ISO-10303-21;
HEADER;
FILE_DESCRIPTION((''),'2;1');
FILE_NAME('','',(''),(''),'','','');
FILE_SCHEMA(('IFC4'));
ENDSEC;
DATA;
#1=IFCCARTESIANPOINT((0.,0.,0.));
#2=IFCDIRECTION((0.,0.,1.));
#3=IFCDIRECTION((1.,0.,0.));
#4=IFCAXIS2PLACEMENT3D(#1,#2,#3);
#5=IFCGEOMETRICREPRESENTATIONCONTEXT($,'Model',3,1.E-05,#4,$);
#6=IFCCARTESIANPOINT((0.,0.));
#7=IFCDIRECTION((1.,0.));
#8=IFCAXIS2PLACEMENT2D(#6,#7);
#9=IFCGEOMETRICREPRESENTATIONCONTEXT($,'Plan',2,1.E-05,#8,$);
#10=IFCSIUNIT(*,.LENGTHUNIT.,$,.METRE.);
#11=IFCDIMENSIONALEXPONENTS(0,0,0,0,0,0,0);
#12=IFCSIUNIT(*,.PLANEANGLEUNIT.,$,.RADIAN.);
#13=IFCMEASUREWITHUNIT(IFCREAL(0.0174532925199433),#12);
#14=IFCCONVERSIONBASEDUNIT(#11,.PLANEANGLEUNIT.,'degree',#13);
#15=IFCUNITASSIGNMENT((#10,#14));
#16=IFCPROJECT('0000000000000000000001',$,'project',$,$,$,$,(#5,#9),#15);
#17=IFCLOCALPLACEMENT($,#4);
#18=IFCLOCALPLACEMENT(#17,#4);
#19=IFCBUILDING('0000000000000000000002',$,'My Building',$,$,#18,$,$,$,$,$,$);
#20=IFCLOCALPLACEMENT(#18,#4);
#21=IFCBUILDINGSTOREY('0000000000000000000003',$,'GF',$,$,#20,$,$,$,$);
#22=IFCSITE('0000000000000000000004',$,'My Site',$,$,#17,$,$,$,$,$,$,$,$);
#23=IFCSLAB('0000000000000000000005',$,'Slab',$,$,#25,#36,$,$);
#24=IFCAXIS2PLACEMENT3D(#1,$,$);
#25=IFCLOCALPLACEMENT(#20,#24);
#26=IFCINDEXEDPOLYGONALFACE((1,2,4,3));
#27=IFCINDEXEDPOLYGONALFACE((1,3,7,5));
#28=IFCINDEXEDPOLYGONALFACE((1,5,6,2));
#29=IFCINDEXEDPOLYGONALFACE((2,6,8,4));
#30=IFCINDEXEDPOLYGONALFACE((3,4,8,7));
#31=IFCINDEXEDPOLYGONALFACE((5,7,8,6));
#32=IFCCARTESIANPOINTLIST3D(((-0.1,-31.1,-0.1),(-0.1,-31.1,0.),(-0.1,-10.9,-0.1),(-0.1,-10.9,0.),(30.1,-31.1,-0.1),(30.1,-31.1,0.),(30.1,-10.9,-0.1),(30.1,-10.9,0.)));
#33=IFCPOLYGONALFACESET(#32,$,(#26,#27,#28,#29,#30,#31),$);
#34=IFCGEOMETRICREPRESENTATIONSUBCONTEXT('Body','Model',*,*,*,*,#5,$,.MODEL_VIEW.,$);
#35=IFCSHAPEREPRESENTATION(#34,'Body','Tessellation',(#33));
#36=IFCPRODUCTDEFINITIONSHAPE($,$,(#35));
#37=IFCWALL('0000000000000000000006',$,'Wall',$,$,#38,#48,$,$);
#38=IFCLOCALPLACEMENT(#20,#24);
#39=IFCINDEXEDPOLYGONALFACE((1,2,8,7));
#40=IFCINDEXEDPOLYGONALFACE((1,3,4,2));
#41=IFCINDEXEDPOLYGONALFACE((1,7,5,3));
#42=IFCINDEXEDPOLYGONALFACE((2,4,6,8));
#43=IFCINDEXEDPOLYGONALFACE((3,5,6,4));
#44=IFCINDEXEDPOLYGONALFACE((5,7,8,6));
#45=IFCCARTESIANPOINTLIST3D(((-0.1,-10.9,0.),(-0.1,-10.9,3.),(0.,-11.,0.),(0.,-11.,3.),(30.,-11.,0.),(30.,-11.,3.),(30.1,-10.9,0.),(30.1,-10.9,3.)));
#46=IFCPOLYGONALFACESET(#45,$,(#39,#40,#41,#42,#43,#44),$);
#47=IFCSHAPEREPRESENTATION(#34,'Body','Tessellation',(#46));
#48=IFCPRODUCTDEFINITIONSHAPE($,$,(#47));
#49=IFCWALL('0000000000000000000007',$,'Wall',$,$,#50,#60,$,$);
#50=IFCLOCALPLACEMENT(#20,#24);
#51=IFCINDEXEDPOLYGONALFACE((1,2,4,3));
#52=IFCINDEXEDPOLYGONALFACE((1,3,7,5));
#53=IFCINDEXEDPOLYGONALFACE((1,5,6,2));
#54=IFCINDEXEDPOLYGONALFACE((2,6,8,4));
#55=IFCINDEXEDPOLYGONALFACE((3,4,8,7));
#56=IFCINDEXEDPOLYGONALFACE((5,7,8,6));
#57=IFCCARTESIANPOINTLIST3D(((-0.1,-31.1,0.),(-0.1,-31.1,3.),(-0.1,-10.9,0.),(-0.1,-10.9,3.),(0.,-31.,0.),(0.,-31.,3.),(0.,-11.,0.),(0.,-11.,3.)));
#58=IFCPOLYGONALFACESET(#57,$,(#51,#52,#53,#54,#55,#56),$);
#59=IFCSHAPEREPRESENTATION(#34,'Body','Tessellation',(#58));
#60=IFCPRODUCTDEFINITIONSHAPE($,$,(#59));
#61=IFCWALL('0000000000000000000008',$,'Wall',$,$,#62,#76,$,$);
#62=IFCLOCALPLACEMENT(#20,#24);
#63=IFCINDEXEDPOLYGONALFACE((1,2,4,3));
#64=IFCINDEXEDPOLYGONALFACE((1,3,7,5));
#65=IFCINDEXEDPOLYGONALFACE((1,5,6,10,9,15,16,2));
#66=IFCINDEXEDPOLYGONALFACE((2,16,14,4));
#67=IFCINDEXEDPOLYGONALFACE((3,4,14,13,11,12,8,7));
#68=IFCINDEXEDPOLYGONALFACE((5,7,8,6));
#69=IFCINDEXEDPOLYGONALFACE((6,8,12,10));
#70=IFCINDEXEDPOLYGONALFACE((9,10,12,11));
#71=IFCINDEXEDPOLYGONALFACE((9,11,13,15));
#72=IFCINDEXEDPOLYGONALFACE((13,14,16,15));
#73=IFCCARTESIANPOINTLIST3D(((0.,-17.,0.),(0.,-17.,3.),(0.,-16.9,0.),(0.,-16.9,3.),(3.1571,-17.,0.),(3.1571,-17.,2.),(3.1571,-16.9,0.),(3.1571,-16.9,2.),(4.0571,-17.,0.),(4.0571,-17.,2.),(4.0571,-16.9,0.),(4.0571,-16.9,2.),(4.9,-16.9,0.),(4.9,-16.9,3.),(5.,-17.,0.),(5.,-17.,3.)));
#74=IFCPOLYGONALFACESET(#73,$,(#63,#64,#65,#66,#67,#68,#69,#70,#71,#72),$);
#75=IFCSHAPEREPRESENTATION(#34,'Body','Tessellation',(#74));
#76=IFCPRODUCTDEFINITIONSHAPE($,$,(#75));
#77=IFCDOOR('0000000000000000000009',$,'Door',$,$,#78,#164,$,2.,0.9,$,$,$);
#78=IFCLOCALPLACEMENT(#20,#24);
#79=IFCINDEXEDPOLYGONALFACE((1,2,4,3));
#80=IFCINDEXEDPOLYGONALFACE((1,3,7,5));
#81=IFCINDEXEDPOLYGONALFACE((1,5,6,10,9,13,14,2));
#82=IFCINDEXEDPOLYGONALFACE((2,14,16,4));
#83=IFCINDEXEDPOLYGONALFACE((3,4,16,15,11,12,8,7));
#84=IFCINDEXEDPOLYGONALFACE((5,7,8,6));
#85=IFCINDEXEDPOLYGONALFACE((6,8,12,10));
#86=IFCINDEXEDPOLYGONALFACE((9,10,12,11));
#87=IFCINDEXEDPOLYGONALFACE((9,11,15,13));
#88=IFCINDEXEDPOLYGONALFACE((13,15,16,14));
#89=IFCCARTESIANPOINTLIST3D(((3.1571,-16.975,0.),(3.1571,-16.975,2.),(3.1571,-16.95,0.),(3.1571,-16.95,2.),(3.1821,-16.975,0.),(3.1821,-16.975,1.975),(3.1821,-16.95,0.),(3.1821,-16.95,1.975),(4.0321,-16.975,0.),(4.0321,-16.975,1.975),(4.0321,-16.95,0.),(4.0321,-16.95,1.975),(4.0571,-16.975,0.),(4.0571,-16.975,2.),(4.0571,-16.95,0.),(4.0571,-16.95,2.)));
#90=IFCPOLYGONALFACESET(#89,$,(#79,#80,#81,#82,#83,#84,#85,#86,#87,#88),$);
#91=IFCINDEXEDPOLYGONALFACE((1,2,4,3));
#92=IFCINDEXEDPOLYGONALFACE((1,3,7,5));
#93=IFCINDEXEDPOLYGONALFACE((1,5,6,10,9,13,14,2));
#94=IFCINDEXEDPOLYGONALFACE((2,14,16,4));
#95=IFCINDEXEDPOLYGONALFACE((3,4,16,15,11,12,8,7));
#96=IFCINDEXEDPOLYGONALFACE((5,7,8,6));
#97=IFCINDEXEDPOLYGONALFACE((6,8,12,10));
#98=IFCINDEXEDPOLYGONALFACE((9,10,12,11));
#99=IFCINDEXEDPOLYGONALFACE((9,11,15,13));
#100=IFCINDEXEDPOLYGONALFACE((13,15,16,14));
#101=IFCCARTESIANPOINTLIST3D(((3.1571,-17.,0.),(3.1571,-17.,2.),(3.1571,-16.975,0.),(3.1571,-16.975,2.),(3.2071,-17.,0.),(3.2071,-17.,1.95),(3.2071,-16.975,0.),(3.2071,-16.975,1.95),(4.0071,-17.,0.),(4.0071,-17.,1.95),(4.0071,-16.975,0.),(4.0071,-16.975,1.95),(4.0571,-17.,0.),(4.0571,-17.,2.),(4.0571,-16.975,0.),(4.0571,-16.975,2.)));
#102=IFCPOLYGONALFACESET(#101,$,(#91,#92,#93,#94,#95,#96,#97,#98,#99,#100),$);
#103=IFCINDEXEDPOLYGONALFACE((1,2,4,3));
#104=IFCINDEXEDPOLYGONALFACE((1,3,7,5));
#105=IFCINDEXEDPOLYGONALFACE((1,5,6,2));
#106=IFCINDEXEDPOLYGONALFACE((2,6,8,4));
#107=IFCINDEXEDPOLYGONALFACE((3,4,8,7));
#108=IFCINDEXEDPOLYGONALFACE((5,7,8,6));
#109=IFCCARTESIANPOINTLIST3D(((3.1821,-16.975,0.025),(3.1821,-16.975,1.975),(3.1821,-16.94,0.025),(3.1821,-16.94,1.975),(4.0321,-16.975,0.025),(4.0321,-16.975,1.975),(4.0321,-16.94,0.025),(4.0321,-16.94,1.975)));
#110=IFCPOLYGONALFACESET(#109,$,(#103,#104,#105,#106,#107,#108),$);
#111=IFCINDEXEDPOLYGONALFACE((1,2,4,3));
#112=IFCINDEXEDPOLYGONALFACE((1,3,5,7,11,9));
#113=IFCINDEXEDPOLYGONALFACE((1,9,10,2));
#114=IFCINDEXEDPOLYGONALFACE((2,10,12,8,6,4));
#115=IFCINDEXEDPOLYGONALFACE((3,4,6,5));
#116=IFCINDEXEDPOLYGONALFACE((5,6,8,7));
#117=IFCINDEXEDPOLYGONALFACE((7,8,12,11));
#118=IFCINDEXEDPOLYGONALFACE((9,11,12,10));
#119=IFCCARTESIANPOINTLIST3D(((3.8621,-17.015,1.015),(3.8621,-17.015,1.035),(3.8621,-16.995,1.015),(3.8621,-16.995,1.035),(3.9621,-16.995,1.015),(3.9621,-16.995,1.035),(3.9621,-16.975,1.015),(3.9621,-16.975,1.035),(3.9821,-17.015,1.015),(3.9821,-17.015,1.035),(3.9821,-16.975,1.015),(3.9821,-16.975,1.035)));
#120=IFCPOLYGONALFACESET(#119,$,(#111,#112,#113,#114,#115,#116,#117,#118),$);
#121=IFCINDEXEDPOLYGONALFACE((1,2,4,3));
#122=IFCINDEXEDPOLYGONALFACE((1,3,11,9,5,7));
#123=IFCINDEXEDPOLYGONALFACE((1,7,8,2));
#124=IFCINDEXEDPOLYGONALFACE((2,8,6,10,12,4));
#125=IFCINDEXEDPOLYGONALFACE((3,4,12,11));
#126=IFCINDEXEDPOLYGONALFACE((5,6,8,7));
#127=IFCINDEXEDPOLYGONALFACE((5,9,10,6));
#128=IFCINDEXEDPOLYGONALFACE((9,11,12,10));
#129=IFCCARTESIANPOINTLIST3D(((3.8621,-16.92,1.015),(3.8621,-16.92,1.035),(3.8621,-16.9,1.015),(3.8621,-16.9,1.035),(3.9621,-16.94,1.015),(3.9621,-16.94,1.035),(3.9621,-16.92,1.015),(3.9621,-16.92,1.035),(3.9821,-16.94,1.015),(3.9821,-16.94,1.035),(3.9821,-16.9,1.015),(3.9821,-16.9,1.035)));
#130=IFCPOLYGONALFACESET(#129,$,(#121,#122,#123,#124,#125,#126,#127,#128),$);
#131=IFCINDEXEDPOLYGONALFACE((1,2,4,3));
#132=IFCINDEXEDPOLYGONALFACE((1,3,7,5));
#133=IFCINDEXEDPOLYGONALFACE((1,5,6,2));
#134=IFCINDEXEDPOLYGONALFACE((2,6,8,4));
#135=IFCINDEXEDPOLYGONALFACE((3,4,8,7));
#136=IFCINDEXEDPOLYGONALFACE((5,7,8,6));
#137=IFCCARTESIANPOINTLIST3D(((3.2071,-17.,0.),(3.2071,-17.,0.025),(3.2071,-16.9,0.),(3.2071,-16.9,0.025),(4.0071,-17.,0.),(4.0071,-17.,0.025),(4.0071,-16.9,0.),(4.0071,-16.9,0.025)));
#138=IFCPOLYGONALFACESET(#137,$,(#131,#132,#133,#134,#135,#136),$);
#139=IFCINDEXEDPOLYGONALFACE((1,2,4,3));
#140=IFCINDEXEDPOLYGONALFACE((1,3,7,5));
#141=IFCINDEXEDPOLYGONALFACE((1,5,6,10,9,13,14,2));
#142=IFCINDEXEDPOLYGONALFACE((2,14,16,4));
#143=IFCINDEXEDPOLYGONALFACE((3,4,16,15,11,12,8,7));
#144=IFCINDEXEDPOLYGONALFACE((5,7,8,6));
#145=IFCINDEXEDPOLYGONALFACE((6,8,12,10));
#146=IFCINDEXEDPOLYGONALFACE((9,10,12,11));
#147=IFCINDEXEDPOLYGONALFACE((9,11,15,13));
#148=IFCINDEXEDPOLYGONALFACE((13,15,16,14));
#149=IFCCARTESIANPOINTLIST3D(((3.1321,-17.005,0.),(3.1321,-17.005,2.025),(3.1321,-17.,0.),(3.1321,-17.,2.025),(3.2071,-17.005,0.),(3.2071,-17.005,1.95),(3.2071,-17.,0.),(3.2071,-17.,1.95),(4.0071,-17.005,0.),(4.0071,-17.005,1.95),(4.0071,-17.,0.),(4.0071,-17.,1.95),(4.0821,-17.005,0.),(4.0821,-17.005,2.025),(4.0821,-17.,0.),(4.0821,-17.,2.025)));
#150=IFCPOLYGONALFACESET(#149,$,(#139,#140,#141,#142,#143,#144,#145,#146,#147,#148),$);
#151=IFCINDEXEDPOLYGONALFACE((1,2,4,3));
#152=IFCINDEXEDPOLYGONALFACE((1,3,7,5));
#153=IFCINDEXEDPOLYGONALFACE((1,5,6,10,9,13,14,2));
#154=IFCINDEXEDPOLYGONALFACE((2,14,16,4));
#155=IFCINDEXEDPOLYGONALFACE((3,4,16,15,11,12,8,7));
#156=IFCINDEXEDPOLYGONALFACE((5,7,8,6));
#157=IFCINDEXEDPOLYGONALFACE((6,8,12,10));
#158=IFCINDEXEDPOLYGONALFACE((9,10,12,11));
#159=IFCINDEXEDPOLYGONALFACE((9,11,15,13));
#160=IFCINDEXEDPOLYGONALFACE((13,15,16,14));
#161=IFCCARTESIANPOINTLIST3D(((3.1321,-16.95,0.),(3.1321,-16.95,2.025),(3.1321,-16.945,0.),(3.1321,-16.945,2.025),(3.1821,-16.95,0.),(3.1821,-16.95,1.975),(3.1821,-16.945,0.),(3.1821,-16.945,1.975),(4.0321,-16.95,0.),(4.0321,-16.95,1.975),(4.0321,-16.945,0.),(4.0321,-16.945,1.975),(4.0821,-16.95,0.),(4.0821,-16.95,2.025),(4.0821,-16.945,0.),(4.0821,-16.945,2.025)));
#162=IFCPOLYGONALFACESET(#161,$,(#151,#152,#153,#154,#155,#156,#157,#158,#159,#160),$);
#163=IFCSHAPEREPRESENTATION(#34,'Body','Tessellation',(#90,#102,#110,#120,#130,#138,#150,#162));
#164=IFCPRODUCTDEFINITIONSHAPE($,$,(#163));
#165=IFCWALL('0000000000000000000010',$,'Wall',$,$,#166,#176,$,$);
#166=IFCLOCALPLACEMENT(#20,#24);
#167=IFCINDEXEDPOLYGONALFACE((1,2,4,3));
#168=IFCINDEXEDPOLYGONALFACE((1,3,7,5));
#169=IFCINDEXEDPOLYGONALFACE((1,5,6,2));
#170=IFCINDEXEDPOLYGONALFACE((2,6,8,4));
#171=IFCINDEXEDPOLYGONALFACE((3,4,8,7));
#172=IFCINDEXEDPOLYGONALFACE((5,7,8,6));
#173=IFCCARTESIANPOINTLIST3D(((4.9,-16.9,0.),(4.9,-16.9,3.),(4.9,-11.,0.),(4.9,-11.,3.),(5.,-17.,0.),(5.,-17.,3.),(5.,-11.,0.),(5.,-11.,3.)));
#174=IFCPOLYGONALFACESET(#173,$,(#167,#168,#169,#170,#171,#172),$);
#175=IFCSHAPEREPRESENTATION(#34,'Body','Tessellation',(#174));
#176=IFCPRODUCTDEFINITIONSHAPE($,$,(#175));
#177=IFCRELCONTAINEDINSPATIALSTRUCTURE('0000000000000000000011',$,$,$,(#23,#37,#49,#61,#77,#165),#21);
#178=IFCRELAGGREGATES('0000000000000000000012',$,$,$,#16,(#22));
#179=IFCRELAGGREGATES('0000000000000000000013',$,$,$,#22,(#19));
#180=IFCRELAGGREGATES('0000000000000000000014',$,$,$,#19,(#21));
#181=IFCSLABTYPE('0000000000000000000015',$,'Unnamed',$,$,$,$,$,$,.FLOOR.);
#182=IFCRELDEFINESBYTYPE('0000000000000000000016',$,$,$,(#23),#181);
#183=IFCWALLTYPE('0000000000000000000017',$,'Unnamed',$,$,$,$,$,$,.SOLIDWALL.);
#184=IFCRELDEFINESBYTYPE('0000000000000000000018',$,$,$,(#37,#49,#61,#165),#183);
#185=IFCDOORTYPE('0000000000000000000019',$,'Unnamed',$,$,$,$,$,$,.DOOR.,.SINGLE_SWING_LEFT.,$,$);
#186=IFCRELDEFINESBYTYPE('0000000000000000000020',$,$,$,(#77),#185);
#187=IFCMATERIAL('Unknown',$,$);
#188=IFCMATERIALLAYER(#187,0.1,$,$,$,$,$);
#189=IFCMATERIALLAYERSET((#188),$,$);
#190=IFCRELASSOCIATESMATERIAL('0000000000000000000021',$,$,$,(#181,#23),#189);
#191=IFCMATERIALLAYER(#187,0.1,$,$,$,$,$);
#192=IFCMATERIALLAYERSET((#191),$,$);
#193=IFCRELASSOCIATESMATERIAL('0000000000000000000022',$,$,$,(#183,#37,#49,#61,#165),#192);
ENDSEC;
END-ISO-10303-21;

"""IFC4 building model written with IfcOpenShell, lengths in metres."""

from ifc_helpers import new_model, entity, si_unit, converted_unit, frame, origin_with_axes, origin_2d_with_axis, place, context, subcontext, project, spatial, line, indexed_curve, outline, extrude, shape, source, transform, mapped, material, layer, layer_set, layer_usage, type_object, type_shapes, element, fill, save


model = new_model("IFC4")

# Units and contexts
model_context = context("Model", 3, precision=1e-05, world=origin_with_axes())
plan_context = context("Plan", 2, precision=1e-05, world=origin_2d_with_axis())
body_context_1 = subcontext(model_context, "Body", "Model", "MODEL_VIEW")
body_context_2 = subcontext(plan_context, "Body", "Plan", "PLAN_VIEW")
ifc_project = project(units=[si_unit("LENGTHUNIT", "METRE"), converted_unit("PLANEANGLEUNIT", "degree", entity("IfcReal", 0.0174532925199433), si_unit("PLANEANGLEUNIT", "RADIAN"), dimensions=[0, 0, 0, 0, 0, 0, 0])], contexts=[model_context, plan_context])

# Site, building, storey
site_placement = place(None, origin_with_axes())
site = spatial("IfcSite", under=ifc_project, at=site_placement, Name="My Site")
building_placement = place(site_placement, origin_with_axes())
building = spatial("IfcBuilding", under=site, at=building_placement, Name="My Building")
storey_placement = place(building_placement, origin_with_axes())
storey = spatial("IfcBuildingStorey", under=building, at=storey_placement, Name="GF")

# Slab
ifc_material = material(Name="Unknown")
ifc_layer_1 = layer(ifc_material, 0.1)
ifc_layer_set_1 = layer_set([ifc_layer_1])
ifc_layer_usage_1 = layer_usage(ifc_layer_set_1, "AXIS3", "POSITIVE", -0.1)
slab_type = type_object("IfcSlabType", Name="Unnamed", PredefinedType="FLOOR", material=ifc_layer_set_1)
slab_1_placement = place(storey_placement, frame((-0.1, -10.9, 0.0), z_axis=(0.0, 0.0, 1.0), x_axis=(1.0, 0.0, 0.0)))
element("IfcSlab", 1, at=slab_1_placement, inside=storey, type_object=slab_type, material=ifc_layer_usage_1, Name="Slab", context=body_context_1, shape_type="SweptSolid", body=[
    extrude(outline(indexed_curve([(0.0, 0.0), (30.2, 0.0), (30.2, -20.2), (0.0, -20.2), (0.0, 0.0)])), frame((0.0, 0.0, -0.1), z_axis=(0.0, 0.0, 1.0), x_axis=(1.0, 0.0, 0.0)), (0.0, 0.0, 1.0), 0.1),
])

# Walls
ifc_layer_2 = layer(ifc_material, 0.1)
ifc_layer_set_2 = layer_set([ifc_layer_2])
ifc_layer_usage_2 = layer_usage(ifc_layer_set_2, "AXIS2", "POSITIVE", 0.0)
wall_type = type_object("IfcWallType", Name="Unnamed", PredefinedType="SOLIDWALL", material=ifc_layer_set_2)
wall_1_placement = place(storey_placement, frame((0.0, -11.0, 0.0), z_axis=(0.0, 0.0, 1.0), x_axis=(1.0, 0.0, 0.0)))
element("IfcWall", 2, at=wall_1_placement, inside=storey, type_object=wall_type, material=ifc_layer_usage_2, Name="Wall", context=body_context_1, shape_type="SweptSolid", body=[
    extrude(outline(indexed_curve([(0.0, 0.0), (-0.1, 0.1), (30.1, 0.1), (30.0, 0.0)], segments=[line(1, 2, 3, 4, 1)])), origin_with_axes(), (0.0, 0.0, 1.0), 3.0),
])
ifc_layer_usage_3 = layer_usage(ifc_layer_set_2, "AXIS2", "POSITIVE", 0.0)
wall_2_placement = place(storey_placement, frame((0.0, -31.0, 0.0), z_axis=(0.0, 0.0, 1.0), x_axis=(0.0, 1.0, 0.0)))
element("IfcWall", 3, at=wall_2_placement, inside=storey, type_object=wall_type, material=ifc_layer_usage_3, Name="Wall", context=body_context_1, shape_type="SweptSolid", body=[
    extrude(outline(indexed_curve([(0.0, 0.0), (-0.1, 0.1), (20.1, 0.1), (20.0, 0.0)], segments=[line(1, 2, 3, 4, 1)])), origin_with_axes(), (0.0, 0.0, 1.0), 3.0),
])

# Wall, opening, door
ifc_layer_usage_4 = layer_usage(ifc_layer_set_2, "AXIS2", "POSITIVE", 0.0)
wall_3_placement = place(storey_placement, frame((0.0, -17.0, 0.0), z_axis=(0.0, 0.0, 1.0), x_axis=(1.0, 0.0, 0.0)))
wall_3 = element("IfcWall", 4, at=wall_3_placement, inside=storey, type_object=wall_type, material=ifc_layer_usage_4, Name="Wall", context=body_context_1, shape_type="SweptSolid", body=[
    extrude(outline(indexed_curve([(0.0, 0.0), (0.0, 0.1), (4.9, 0.1), (5.0, 0.0)], segments=[line(1, 2, 3, 4, 1)])), origin_with_axes(), (0.0, 0.0, 1.0), 3.0),
])
shared_shape_1 = source(origin_with_axes(), body_context_1, "Body", "SweptSolid", [
    extrude(outline(indexed_curve([(0.0, 0.0), (0.9, 0.0), (0.9, 2.0), (0.0, 2.0)], segments=[line(1, 2, 3, 4, 1)])), frame((0.0, -0.6, 0.0), z_axis=(0.0, -1.0, 0.0), x_axis=(1.0, 0.0, 0.0)), (0.0, 0.0, -1.0), 1.2),
])
opening_1_placement = place(wall_3_placement, frame((3.1571, 0.0, 0.0), z_axis=(0.0, 0.0, 1.0), x_axis=(1.0, 0.0, 0.0)))
opening_1 = element("IfcOpeningElement", 5, at=opening_1_placement, cuts=wall_3, PredefinedType="OPENING", context=body_context_1, shape_type="MappedRepresentation", body=[
    mapped(shared_shape_1, transform((0.0, 0.0, 0.0), x_axis=(1.0, 0.0, 0.0), y_axis=(0.0, 1.0, 0.0), z_axis=(0.0, 0.0, 1.0), scale=1.0)),
])
door_type = type_object("IfcDoorType", Name="Unnamed", OperationType="SINGLE_SWING_LEFT", PredefinedType="DOOR")
shared_shape_2 = source(origin_with_axes(), body_context_1, "Body", "SweptSolid", [
    extrude(outline(indexed_curve([(0.0, 0.0), (0.0, 2.0), (0.9, 2.0), (0.9, 0.0), (0.875, 0.0), (0.875, 1.975), (0.025, 1.975), (0.025, 0.0)], segments=[line(1, 2, 3, 4, 5, 6, 7, 8, 1)])), frame((0.0, 0.025, 0.0), z_axis=(0.0, -1.0, 0.0), x_axis=(1.0, 0.0, 0.0)), (0.0, 0.0, -1.0), 0.025),
    extrude(outline(indexed_curve([(0.0, 0.0), (0.0, 2.0), (0.9, 2.0), (0.9, 0.0), (0.85, 0.0), (0.85, 1.95), (0.05, 1.95), (0.05, 0.0)], segments=[line(1, 2, 3, 4, 5, 6, 7, 8, 1)])), frame((0.0, 0.0, 0.0), z_axis=(0.0, -1.0, 0.0), x_axis=(1.0, 0.0, 0.0)), (0.0, 0.0, -1.0), 0.025),
    extrude(outline(indexed_curve([(0.0, 0.0), (0.85, 0.0), (0.85, 0.035), (0.0, 0.035)], segments=[line(1, 2, 3, 4, 1)])), frame((0.025, 0.025, 0.025), z_axis=(0.0, 0.0, 1.0), x_axis=(1.0, 0.0, 0.0)), (0.0, 0.0, 1.0), 1.95),
    extrude(outline(indexed_curve([(0.0, 0.0), (0.0, -0.04), (-0.12, -0.04), (-0.12, -0.02), (-0.02, -0.02), (-0.02, 0.0)], segments=[line(1, 2, 3, 4, 5, 6, 1)])), frame((0.825, 0.025, 1.015), z_axis=(0.0, 0.0, 1.0), x_axis=(1.0, 0.0, 0.0)), (0.0, 0.0, 1.0), 0.02),
    extrude(outline(indexed_curve([(0.0, 0.0), (0.0, 0.04), (-0.12, 0.04), (-0.12, 0.02), (-0.02, 0.02), (-0.02, 0.0)], segments=[line(1, 2, 3, 4, 5, 6, 1)])), frame((0.825, 0.06, 1.015), z_axis=(0.0, 0.0, 1.0), x_axis=(1.0, 0.0, 0.0)), (0.0, 0.0, 1.0), 0.02),
    extrude(outline(indexed_curve([(0.0, 0.0), (0.8, 0.0), (0.8, 0.1), (0.0, 0.1)], segments=[line(1, 2, 3, 4, 1)])), frame((0.05, 0.0, 0.0), z_axis=(0.0, 0.0, 1.0), x_axis=(1.0, 0.0, 0.0)), (0.0, 0.0, 1.0), 0.025),
    extrude(outline(indexed_curve([(0.0, 0.0), (0.0, 2.025), (0.95, 2.025), (0.95, 0.0), (0.875, 0.0), (0.875, 1.95), (0.075, 1.95), (0.075, 0.0)], segments=[line(1, 2, 3, 4, 5, 6, 7, 8, 1)])), frame((-0.025, -0.005, 0.0), z_axis=(0.0, -1.0, 0.0), x_axis=(1.0, 0.0, 0.0)), (0.0, 0.0, -1.0), 0.005),
    extrude(outline(indexed_curve([(0.0, 0.0), (0.0, 2.025), (0.95, 2.025), (0.95, 0.0), (0.9, 0.0), (0.9, 1.975), (0.05, 1.975), (0.05, 0.0)], segments=[line(1, 2, 3, 4, 5, 6, 7, 8, 1)])), frame((-0.025, 0.05, 0.0), z_axis=(0.0, -1.0, 0.0), x_axis=(1.0, 0.0, 0.0)), (0.0, 0.0, -1.0), 0.005),
])
shared_shape_3 = source(origin_with_axes(), body_context_2, "Body", "Curve2D", [
    entity("IfcIndexedPolyCurve", entity("IfcCartesianPointList2D", [[0.0, 0.0], [0.0, 0.05], [0.025, 0.05], [0.025, 0.025], [0.05, 0.025], [0.05, 0.0]]), [entity("IfcLineIndex", [1, 2, 3, 4, 5, 6, 1])]),
    entity("IfcIndexedPolyCurve", entity("IfcCartesianPointList2D", [[0.9, 0.0], [0.9, 0.05], [0.875, 0.05], [0.875, 0.025], [0.85, 0.025], [0.85, 0.0]]), [entity("IfcLineIndex", [1, 2, 3, 4, 5, 6, 1])]),
    entity("IfcTrimmedCurve", entity("IfcEllipse", entity("IfcAxis2Placement2D", entity("IfcCartesianPoint", [0.06, 0.05]), entity("IfcDirection", [1.0, 0.0])), 0.815, 0.85), [entity("IfcCartesianPoint", [0.875, 0.05])], [entity("IfcCartesianPoint", [0.06, 0.9])], True, "CARTESIAN"),
    entity("IfcIndexedPolyCurve", entity("IfcCartesianPointList2D", [[0.025, 0.05], [0.06, 0.05], [0.06, 0.9], [0.025, 0.9]]), [entity("IfcLineIndex", [1, 2, 3, 4, 1])]),
])
type_shapes(door_type, [shared_shape_2, shared_shape_3])
door_1_placement = place(opening_1_placement, origin_with_axes())
door_1 = element("IfcDoor", 6, at=door_1_placement, inside=storey, type_object=door_type, Name="Door", OverallHeight=2.0, OverallWidth=0.9, shapes=[
    shape(body_context_1, "Body", "MappedRepresentation", [mapped(shared_shape_2, transform((0.0, 0.0, 0.0), x_axis=(1.0, 0.0, 0.0), y_axis=(0.0, 1.0, 0.0), z_axis=(0.0, 0.0, 1.0), scale=1.0))]),
    shape(body_context_2, "Body", "MappedRepresentation", [mapped(shared_shape_3, transform((0.0, 0.0, 0.0), x_axis=(1.0, 0.0, 0.0), y_axis=(0.0, 1.0, 0.0), z_axis=(0.0, 0.0, 1.0), scale=1.0))]),
])
fill(opening_1, door_1)

# Wall
ifc_layer_usage_5 = layer_usage(ifc_layer_set_2, "AXIS2", "POSITIVE", 0.0)
wall_4_placement = place(storey_placement, frame((5.0, -17.0, 0.0), z_axis=(0.0, 0.0, 1.0), x_axis=(0.0, 1.0, 0.0)))
element("IfcWall", 7, at=wall_4_placement, inside=storey, type_object=wall_type, material=ifc_layer_usage_5, Name="Wall", context=body_context_1, shape_type="SweptSolid", body=[
    extrude(outline(indexed_curve([(0.0, 0.0), (0.1, 0.1), (6.0, 0.1), (6.0, 0.0)], segments=[line(1, 2, 3, 4, 1)])), origin_with_axes(), (0.0, 0.0, 1.0), 3.0),
])

save(model, "model.ifc")
